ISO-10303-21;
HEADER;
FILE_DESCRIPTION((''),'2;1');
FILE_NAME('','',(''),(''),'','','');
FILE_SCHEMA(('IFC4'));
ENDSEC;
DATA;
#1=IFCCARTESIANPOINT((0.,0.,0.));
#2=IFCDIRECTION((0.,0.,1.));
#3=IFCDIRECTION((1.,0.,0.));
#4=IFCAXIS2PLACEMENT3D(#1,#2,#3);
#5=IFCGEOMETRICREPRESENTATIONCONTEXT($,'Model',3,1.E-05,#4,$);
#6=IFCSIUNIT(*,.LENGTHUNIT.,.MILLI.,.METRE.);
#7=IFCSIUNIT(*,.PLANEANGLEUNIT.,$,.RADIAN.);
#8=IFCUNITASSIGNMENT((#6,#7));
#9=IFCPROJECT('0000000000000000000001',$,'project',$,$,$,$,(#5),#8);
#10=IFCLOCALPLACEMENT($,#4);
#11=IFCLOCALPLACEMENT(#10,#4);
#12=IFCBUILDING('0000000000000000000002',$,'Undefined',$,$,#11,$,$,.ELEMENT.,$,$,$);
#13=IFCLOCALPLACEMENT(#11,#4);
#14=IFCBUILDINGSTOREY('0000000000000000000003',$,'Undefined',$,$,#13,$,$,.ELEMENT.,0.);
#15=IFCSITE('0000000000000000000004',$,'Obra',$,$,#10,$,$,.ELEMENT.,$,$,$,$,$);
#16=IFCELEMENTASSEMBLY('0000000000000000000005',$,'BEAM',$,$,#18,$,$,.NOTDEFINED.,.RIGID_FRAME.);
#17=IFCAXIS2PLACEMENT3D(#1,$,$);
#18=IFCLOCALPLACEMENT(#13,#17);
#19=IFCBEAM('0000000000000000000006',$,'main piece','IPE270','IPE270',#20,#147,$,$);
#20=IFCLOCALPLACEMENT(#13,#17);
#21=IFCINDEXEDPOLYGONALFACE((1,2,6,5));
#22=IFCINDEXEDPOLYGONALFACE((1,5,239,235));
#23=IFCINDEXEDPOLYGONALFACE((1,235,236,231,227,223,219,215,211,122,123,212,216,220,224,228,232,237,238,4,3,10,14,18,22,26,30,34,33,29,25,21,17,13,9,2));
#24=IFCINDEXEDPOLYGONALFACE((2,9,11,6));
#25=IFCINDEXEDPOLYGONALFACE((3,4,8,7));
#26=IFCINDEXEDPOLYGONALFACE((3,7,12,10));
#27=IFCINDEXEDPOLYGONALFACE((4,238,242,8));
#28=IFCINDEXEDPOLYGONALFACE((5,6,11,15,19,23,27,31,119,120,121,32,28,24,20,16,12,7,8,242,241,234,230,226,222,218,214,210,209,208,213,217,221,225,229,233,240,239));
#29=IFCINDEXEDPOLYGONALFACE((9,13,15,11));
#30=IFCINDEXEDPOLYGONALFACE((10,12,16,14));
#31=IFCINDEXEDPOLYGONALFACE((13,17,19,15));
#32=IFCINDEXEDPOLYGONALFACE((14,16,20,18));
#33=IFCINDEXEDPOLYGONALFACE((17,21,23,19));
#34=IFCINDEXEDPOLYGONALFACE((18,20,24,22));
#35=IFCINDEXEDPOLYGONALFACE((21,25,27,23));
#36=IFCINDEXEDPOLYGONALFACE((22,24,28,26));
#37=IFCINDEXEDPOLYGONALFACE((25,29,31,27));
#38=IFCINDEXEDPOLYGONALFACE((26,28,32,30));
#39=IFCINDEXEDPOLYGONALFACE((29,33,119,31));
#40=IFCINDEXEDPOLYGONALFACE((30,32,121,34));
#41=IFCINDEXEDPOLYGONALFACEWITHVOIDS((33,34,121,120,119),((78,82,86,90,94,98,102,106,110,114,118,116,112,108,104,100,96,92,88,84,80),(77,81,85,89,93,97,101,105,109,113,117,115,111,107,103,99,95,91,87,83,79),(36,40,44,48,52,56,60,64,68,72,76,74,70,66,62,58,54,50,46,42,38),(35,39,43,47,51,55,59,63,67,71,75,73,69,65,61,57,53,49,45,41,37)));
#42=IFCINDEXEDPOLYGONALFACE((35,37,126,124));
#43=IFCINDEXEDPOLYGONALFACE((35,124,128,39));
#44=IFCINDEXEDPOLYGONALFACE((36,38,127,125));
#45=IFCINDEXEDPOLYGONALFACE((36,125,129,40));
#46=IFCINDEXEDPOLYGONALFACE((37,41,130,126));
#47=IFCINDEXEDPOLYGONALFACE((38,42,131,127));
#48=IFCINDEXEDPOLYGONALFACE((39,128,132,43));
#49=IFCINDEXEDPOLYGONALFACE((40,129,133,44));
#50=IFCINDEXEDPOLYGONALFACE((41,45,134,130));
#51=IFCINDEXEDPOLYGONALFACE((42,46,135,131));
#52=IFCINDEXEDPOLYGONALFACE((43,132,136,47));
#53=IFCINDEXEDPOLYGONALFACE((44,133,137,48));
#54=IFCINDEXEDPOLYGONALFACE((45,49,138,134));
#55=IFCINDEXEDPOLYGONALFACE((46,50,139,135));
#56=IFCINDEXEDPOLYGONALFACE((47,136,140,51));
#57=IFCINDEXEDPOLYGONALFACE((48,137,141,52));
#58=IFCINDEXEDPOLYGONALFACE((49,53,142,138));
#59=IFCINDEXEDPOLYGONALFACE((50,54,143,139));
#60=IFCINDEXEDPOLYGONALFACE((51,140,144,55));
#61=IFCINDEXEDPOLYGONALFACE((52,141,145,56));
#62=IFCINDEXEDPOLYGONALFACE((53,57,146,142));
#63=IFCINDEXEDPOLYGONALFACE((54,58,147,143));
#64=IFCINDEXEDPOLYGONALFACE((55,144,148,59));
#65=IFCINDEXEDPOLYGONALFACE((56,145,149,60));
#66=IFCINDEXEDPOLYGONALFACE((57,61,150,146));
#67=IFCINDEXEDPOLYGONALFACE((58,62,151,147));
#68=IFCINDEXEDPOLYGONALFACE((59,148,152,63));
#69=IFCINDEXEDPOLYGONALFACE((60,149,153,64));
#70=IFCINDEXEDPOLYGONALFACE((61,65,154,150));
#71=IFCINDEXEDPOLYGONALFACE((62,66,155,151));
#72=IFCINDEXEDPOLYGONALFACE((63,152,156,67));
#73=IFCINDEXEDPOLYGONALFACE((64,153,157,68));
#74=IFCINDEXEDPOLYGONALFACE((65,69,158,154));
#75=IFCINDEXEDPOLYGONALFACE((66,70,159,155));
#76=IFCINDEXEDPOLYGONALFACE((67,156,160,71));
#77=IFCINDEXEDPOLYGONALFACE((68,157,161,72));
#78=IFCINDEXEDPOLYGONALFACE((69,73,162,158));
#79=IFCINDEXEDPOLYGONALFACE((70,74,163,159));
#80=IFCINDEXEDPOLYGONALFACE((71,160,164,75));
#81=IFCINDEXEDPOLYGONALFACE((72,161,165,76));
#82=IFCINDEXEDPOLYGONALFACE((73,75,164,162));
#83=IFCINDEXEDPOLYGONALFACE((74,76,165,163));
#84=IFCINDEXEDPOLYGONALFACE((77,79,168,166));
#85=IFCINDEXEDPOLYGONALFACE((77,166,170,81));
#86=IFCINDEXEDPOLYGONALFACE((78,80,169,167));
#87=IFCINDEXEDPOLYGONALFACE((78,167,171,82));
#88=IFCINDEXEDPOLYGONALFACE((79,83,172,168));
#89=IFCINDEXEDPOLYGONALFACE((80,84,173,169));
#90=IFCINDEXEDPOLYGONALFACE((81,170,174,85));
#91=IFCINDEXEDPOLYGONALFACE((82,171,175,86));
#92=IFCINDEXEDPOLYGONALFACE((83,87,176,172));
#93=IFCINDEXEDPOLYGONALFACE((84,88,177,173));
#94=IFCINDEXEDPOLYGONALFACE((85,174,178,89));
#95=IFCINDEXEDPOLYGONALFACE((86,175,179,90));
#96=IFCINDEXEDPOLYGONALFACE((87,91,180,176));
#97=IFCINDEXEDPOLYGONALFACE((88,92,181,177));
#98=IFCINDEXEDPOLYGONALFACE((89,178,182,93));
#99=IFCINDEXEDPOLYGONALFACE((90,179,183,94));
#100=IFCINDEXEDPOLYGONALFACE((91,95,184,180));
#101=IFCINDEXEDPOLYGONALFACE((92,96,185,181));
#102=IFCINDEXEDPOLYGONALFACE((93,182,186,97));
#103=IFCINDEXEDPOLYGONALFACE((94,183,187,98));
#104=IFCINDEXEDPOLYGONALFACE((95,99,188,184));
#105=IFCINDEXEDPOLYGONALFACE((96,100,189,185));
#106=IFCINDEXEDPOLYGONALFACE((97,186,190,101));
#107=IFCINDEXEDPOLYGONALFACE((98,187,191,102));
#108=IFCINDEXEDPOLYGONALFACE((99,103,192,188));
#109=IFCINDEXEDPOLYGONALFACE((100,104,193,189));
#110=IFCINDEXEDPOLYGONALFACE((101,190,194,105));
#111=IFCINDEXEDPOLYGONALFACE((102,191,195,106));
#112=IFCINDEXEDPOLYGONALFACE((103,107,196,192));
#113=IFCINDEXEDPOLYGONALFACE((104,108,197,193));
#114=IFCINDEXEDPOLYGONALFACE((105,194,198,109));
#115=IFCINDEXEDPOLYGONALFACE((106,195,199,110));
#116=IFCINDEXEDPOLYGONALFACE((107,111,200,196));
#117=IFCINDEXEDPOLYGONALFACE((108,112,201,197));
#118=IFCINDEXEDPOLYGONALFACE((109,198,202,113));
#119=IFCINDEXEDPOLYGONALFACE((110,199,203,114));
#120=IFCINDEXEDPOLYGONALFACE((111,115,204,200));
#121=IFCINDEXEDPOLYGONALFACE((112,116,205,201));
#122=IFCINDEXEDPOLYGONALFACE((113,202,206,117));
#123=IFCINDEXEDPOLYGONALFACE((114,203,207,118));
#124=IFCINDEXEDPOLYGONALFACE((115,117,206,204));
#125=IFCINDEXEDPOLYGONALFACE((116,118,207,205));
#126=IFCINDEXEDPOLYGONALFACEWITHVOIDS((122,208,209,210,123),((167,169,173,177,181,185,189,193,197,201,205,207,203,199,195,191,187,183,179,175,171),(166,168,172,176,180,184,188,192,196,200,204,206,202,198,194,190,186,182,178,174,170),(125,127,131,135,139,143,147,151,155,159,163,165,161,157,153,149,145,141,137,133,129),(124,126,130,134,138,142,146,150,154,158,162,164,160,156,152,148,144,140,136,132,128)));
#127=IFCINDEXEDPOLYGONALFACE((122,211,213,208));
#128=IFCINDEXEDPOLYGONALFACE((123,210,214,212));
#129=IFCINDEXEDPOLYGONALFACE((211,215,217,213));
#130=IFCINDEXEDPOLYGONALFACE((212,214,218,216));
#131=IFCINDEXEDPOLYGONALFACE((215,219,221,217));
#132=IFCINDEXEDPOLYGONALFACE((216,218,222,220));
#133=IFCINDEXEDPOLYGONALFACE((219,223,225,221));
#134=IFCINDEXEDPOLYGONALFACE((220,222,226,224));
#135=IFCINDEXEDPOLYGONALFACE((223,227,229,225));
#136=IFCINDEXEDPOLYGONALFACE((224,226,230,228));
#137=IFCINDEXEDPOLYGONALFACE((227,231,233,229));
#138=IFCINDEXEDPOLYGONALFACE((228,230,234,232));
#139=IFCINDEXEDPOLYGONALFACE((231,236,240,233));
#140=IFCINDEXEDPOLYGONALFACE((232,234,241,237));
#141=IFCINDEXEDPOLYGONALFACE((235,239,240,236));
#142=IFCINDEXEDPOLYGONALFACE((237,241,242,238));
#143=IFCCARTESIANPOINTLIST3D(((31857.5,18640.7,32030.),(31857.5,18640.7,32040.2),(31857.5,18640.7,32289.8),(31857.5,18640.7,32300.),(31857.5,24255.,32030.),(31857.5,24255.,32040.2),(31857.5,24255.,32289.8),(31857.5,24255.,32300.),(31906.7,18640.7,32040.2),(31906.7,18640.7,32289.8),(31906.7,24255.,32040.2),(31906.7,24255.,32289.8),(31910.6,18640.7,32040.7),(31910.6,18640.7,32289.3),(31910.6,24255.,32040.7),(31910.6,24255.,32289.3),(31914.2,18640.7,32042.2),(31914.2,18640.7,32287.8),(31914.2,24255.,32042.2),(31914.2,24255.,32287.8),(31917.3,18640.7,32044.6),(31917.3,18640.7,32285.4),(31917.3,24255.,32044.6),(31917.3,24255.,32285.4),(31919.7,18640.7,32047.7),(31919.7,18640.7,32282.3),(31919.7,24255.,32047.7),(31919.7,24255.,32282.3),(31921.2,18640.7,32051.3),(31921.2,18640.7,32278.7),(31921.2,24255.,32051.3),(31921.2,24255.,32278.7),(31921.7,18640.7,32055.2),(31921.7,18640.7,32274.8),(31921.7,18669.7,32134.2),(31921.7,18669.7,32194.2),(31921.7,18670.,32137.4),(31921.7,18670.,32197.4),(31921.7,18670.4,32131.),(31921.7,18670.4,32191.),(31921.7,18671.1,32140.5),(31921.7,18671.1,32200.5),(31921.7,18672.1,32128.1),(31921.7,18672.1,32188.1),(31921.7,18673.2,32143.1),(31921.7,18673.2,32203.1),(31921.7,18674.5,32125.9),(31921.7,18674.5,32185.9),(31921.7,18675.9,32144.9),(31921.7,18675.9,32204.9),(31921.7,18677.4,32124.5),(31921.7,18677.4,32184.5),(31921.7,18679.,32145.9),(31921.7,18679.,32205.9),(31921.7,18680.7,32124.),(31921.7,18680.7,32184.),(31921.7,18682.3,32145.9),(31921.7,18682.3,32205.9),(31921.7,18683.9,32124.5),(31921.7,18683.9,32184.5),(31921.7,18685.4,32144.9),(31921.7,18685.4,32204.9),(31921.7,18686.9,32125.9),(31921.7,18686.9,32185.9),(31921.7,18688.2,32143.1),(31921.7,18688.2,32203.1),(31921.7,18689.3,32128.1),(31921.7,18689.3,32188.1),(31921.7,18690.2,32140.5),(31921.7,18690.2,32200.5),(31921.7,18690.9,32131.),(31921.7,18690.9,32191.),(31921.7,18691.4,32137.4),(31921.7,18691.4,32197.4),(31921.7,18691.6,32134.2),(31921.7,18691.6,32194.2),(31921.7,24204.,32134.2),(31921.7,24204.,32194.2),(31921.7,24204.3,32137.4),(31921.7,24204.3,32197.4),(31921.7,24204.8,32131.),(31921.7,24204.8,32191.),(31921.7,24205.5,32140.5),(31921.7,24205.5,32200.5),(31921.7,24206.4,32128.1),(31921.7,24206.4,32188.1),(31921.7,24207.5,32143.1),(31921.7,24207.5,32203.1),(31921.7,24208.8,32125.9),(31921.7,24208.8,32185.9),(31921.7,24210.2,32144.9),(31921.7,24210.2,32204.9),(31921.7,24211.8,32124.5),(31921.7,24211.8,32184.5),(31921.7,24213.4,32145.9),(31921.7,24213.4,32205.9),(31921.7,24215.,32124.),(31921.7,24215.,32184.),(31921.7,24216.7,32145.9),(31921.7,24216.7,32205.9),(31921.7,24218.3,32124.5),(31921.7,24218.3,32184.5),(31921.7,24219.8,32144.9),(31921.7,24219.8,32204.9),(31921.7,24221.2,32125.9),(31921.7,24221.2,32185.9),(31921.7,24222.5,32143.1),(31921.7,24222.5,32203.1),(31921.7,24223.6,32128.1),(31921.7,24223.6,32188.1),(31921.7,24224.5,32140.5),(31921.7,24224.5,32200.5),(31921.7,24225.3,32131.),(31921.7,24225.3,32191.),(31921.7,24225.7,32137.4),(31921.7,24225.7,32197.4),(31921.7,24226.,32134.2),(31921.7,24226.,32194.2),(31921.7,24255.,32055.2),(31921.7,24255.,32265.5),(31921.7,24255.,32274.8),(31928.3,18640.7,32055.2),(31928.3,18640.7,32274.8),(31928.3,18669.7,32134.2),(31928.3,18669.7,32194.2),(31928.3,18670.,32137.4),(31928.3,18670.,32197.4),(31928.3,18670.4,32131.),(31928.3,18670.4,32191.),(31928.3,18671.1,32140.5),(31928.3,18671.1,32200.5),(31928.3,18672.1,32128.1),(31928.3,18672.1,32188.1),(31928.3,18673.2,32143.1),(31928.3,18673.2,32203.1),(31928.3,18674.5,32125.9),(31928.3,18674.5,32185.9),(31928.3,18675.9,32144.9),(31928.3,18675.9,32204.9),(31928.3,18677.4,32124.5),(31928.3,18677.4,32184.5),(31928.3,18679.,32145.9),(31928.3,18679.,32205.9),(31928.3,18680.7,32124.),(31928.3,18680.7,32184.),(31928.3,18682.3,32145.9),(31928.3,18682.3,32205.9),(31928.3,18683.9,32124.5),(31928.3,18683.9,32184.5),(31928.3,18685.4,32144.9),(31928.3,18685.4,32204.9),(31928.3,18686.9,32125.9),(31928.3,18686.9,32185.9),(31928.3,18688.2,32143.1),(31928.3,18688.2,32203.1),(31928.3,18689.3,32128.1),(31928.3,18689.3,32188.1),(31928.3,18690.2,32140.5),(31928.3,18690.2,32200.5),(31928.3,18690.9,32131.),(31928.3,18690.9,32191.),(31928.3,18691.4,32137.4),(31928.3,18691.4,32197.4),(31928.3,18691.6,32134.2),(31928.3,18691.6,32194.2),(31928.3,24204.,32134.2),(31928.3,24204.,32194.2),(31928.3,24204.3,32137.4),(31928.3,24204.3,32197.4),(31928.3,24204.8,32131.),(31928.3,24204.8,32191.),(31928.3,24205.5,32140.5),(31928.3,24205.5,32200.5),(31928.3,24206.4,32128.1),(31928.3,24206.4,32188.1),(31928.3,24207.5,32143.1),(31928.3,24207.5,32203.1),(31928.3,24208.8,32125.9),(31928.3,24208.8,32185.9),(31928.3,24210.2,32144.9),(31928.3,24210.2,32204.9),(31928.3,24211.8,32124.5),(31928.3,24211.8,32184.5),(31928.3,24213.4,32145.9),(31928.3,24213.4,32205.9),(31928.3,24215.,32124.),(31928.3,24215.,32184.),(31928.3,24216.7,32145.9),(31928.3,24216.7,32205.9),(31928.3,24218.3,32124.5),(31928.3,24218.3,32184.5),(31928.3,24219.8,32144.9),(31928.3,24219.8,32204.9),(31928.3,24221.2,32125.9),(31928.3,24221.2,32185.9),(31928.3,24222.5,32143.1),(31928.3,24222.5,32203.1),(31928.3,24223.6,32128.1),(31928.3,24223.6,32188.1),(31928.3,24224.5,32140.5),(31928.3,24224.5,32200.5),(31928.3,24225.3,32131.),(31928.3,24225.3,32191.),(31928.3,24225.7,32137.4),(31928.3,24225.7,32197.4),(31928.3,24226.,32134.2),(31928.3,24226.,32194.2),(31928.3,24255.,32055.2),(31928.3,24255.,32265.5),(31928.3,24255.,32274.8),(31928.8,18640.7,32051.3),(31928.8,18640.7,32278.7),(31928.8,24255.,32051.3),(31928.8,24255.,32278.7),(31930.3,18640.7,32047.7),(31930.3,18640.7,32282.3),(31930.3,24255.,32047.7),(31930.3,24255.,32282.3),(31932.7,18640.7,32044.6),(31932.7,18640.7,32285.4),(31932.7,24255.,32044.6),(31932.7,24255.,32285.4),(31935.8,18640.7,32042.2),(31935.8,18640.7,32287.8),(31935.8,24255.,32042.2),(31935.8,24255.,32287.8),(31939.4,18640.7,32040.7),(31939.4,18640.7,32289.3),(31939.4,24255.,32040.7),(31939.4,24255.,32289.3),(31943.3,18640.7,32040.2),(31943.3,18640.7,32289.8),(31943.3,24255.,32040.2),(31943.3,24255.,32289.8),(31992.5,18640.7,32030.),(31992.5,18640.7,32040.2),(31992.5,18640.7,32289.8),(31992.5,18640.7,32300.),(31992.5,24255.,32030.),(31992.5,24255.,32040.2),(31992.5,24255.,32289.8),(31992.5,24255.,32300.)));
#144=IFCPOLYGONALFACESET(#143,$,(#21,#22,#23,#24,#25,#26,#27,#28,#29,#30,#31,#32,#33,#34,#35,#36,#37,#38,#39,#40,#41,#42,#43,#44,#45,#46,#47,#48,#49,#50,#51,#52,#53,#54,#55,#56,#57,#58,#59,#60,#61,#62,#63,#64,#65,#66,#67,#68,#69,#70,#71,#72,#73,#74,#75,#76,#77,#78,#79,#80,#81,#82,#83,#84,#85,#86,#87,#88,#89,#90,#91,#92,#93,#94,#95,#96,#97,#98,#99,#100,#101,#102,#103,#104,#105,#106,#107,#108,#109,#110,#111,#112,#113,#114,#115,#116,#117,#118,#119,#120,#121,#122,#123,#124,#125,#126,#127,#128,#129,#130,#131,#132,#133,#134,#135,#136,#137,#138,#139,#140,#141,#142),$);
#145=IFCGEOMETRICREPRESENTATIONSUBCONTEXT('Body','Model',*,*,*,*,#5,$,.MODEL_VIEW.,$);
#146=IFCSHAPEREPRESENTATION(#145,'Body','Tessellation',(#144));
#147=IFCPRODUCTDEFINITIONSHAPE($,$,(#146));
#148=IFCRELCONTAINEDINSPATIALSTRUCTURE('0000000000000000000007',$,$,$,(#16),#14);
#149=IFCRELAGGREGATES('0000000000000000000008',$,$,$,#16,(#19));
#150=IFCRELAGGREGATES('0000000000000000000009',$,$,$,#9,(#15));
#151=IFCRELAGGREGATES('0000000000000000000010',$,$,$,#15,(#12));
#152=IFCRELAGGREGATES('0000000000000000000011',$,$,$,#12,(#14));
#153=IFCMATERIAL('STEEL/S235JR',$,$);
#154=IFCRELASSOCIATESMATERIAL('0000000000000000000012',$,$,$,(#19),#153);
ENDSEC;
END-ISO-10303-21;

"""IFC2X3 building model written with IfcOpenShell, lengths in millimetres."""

from ifc_helpers import new_model, si_unit, frame, origin_with_axes, origin_2d_with_axis, place, context, subcontext, project, spatial, rectangle, circle, i_section, extrude, clip, halfspace, source, transform, mapped, material, element, aggregate, save


model = new_model("IFC2X3")

# Units and contexts
model_context = context("Model", 3, precision=1e-05, world=origin_with_axes())
body_context = subcontext(model_context, "Body", "Model", "MODEL_VIEW")
ifc_project = project(units=[si_unit("LENGTHUNIT", "METRE", prefix="MILLI"), si_unit("PLANEANGLEUNIT", "RADIAN")], contexts=[model_context])

# Site, building, storey
site_placement = place(None, origin_with_axes())
site = spatial("IfcSite", under=ifc_project, at=site_placement, Name="Obra", CompositionType="ELEMENT")
building_placement = place(site_placement, origin_with_axes())
building = spatial("IfcBuilding", under=site, at=building_placement, Name="Undefined", CompositionType="ELEMENT")
storey_placement = place(building_placement, origin_with_axes())
storey = spatial("IfcBuildingStorey", under=building, at=storey_placement, Name="Undefined", CompositionType="ELEMENT", Elevation=0.0)

# Element assembly, beam, openings
ifc_material_1 = material(Name="STEEL/S235JR")
shared_shape_1 = source(origin_with_axes(), body_context, "Body", "SweptSolid", [
    extrude(circle(Radius=11.0, at=origin_2d_with_axis()), frame((0.0, -3.4, 0.0), z_axis=(0.0, 1.0, 0.0), x_axis=(1.0, 0.0, 0.0)), (0.0, 0.0, 1.0), 6.8),
])
assembly_1_placement = place(storey_placement, origin_with_axes())
assembly_1 = element("IfcElementAssembly", 1, at=assembly_1_placement, inside=storey, Name="BEAM", AssemblyPlace="NOTDEFINED", PredefinedType="RIGID_FRAME")
beam_1_placement = place(assembly_1_placement, frame((31925.0, 18635.9, 32165.0), z_axis=(0.0, 0.0, 1.0), x_axis=(0.0, 1.0, 0.0)))
beam_1 = element("IfcBeam", 2, at=beam_1_placement, material=ifc_material_1, Name="main piece", Description="IPE270", ObjectType="IPE270", context=body_context, shape_type="Clipping", body=[
    clip(clip(extrude(i_section(OverallWidth=135.0, OverallDepth=270.0, WebThickness=6.6, FlangeThickness=10.2, FilletRadius=15.0, at=origin_2d_with_axis()), frame((5619.1, 0.0, 0.0), z_axis=(-1.0, 0.0, 0.0), x_axis=(0.0, -1.0, 0.0)), (0.0, 0.0, 1.0), 5614.3), halfspace(frame((5619.1, 0.0, -235.0), z_axis=(-1.0, -0.000001, 0.0), x_axis=(-0.000002, 1.0, 0.0)), True)), halfspace(frame((4.8, 0.0, -235.0), z_axis=(1.0, 0.0, 0.0), x_axis=(0.0, -1.0, 0.0)), True)),
])
opening_1_placement = place(assembly_1_placement, frame((31925.0, 18635.9, 32165.0), z_axis=(0.0, 0.0, 1.0), x_axis=(0.0, 1.0, 0.0)))
element("IfcOpeningElement", 3, at=opening_1_placement, cuts=beam_1, ObjectType="Recess", context=body_context, shape_type="SweptSolid", body=[
    extrude(rectangle(XDim=26.2, YDim=76.2, at=origin_2d_with_axis()), frame((-33.3, -68.5, -122.9), z_axis=(0.0, 1.0, 0.0), x_axis=(0.0, 0.0, -1.0)), (0.0, 0.0, 1.0), 137.0),
])
opening_2_placement = place(assembly_1_placement, frame((31925.0, 18635.9, 32165.0), z_axis=(0.0, 0.0, 1.0), x_axis=(0.0, 1.0, 0.0)))
element("IfcOpeningElement", 4, at=opening_2_placement, cuts=beam_1, ObjectType="Recess", context=body_context, shape_type="SweptSolid", body=[
    extrude(rectangle(XDim=26.2, YDim=76.2, at=origin_2d_with_axis()), frame((-33.3, -68.5, 122.9), z_axis=(0.0, 1.0, 0.0), x_axis=(0.0, 0.0, -1.0)), (0.0, 0.0, 1.0), 137.0),
])
opening_3_placement = place(assembly_1_placement, frame((31925.0, 18635.9, 32165.0), z_axis=(0.0, 0.0, 1.0), x_axis=(0.0, 1.0, 0.0)))
element("IfcOpeningElement", 5, at=opening_3_placement, cuts=beam_1, ObjectType="Recess", context=body_context, shape_type="SweptSolid", body=[
    extrude(rectangle(XDim=35.5, YDim=97.7, at=origin_2d_with_axis()), frame((5668.0, 68.5, 118.2), z_axis=(0.000001, -1.0, 0.0), x_axis=(0.0, 0.0, -1.0)), (0.0, 0.0, 1.0), 137.0),
])
opening_4_placement = place(assembly_1_placement, frame((31925.0, 18635.9, 32165.0), z_axis=(0.0, 0.0, 1.0), x_axis=(0.0, 1.0, 0.0)))
element("IfcOpeningElement", 6, at=opening_4_placement, cuts=beam_1, ObjectType="Recess", context=body_context, shape_type="SweptSolid", body=[
    extrude(rectangle(XDim=26.2, YDim=76.2, at=origin_2d_with_axis()), frame((-33.3, -68.5, -122.9), z_axis=(0.0, 1.0, 0.0), x_axis=(0.0, 0.0, -1.0)), (0.0, 0.0, 1.0), 137.0),
])
opening_5_placement = place(assembly_1_placement, frame((31925.0, 18635.9, 32165.0), z_axis=(0.0, 0.0, 1.0), x_axis=(0.0, 1.0, 0.0)))
element("IfcOpeningElement", 7, at=opening_5_placement, cuts=beam_1, ObjectType="Recess", context=body_context, shape_type="SweptSolid", body=[
    extrude(rectangle(XDim=26.2, YDim=76.2, at=origin_2d_with_axis()), frame((-33.3, -68.5, 122.9), z_axis=(0.0, 1.0, 0.0), x_axis=(0.0, 0.0, -1.0)), (0.0, 0.0, 1.0), 137.0),
])
opening_6_placement = place(assembly_1_placement, frame((31925.0, 18640.7, 32235.0), z_axis=(0.0, 1.0, 0.0), x_axis=(0.0, 0.0, -1.0)))
element("IfcOpeningElement", 8, at=opening_6_placement, cuts=beam_1, ObjectType="Opening", context=body_context, shape_type="MappedRepresentation", body=[
    mapped(shared_shape_1, transform((40.0, 0.0, 40.0))),
    mapped(shared_shape_1, transform((100.0, 0.0, 40.0))),
])
shared_shape_2 = source(origin_with_axes(), body_context, "Body", "SweptSolid", [
    extrude(circle(Radius=11.0, at=origin_2d_with_axis()), frame((0.0, -3.4, 0.0), z_axis=(0.0, 1.0, 0.0), x_axis=(1.0, 0.0, 0.0)), (0.0, 0.0, 1.0), 6.8),
])
opening_7_placement = place(assembly_1_placement, frame((31925.0, 24255.0, 32235.0), z_axis=(0.000001, -1.0, 0.0), x_axis=(0.0, 0.0, -1.0)))
element("IfcOpeningElement", 9, at=opening_7_placement, cuts=beam_1, ObjectType="Opening", context=body_context, shape_type="MappedRepresentation", body=[
    mapped(shared_shape_2, transform((40.0, 0.0, 40.0))),
    mapped(shared_shape_2, transform((100.0, 0.0, 40.0))),
])

aggregate(assembly_1, [beam_1])

save(model, "model.ifc")
